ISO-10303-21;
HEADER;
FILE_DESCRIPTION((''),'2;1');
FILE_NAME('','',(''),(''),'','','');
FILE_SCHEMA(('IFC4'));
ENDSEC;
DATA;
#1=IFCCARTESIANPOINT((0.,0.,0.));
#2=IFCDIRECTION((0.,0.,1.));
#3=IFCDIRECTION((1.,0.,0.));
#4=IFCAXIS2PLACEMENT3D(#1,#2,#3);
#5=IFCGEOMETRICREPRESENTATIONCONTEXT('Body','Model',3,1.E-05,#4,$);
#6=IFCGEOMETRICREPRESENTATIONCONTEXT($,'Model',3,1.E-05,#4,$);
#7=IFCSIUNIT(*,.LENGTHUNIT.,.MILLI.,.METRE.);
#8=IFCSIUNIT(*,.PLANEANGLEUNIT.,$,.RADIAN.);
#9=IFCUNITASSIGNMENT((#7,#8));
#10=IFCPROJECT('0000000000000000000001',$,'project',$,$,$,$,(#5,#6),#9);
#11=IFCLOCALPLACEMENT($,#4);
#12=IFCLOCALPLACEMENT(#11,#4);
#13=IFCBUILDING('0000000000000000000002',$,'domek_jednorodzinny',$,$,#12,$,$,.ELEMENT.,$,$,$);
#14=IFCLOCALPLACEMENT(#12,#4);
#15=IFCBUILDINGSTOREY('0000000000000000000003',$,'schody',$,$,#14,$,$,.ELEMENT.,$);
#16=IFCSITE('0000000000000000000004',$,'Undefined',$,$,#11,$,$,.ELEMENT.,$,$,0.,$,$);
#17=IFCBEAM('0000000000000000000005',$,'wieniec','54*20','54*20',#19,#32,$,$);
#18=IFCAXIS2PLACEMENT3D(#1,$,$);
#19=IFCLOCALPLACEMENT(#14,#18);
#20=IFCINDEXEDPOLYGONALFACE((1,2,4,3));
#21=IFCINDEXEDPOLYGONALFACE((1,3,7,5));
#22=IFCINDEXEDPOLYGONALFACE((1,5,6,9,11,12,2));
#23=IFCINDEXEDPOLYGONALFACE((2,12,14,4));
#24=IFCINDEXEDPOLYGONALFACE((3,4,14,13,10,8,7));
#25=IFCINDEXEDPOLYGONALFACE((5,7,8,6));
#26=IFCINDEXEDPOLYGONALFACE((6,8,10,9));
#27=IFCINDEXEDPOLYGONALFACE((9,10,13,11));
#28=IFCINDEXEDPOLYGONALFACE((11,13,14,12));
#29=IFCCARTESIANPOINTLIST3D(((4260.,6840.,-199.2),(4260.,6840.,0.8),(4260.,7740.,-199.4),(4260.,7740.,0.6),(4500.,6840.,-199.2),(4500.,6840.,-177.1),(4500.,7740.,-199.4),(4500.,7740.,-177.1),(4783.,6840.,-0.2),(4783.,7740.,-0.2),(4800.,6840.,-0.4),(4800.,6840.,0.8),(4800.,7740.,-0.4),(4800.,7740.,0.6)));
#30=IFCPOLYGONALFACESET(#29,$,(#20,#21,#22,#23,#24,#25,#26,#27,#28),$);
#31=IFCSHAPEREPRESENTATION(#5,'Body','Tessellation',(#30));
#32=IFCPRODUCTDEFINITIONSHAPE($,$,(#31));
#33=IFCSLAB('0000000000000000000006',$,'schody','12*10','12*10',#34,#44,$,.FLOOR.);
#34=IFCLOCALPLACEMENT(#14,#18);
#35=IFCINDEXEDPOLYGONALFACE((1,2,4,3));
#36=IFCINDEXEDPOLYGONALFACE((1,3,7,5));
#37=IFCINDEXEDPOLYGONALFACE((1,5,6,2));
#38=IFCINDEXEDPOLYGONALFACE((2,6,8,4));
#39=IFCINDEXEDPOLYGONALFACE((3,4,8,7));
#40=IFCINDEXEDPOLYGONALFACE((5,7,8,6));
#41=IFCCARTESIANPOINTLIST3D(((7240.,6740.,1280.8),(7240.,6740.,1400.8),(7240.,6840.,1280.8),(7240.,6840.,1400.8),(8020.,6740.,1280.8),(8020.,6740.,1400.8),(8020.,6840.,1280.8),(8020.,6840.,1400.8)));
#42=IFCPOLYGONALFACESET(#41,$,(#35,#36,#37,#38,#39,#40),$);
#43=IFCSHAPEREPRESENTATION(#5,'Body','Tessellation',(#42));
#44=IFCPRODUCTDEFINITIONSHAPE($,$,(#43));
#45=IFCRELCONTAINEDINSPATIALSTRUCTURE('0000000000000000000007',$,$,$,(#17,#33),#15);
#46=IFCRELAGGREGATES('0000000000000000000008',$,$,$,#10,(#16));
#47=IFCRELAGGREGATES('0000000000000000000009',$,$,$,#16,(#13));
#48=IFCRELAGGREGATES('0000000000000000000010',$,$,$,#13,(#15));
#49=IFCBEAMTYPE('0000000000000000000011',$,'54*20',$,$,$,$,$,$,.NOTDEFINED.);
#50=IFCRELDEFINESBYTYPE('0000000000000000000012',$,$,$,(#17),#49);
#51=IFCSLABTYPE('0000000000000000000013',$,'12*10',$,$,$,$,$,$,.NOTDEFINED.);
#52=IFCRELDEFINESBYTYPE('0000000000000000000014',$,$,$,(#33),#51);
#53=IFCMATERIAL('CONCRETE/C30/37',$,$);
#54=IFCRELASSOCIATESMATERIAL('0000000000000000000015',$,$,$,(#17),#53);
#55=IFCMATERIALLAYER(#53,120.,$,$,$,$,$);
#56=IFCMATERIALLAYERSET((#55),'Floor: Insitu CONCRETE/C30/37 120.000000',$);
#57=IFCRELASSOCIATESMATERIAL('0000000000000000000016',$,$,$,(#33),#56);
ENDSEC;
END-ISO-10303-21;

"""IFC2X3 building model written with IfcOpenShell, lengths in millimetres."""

from ifc_helpers import new_model, si_unit, frame, origin_with_axes, origin_2d_with_axis, place, context, project, spatial, polyline, rectangle, outline, extrude, material, layer, layer_set, layer_usage, type_object, element, save


model = new_model("IFC2X3")

# Units and contexts
model_context_1 = context("Model", 3, precision=1e-05, world=origin_with_axes(), identifier="Body")
model_context_2 = context("Model", 3, precision=1e-05, world=origin_with_axes())
ifc_project = project(units=[si_unit("LENGTHUNIT", "METRE", prefix="MILLI"), si_unit("PLANEANGLEUNIT", "RADIAN")], contexts=[model_context_1, model_context_2])

# Site, building, storey
site_placement = place(None, origin_with_axes())
site = spatial("IfcSite", under=ifc_project, at=site_placement, Name="Undefined", CompositionType="ELEMENT", RefElevation=0.0)
building_placement = place(site_placement, origin_with_axes())
building = spatial("IfcBuilding", under=site, at=building_placement, Name="domek_jednorodzinny", CompositionType="ELEMENT")
storey_placement = place(building_placement, origin_with_axes())
storey = spatial("IfcBuildingStorey", under=building, at=storey_placement, Name="schody", CompositionType="ELEMENT")

# Beam, opening
ifc_material = material(Name="CONCRETE/C30/37")
beam_type = type_object("IfcBeamType", Name="54*20", PredefinedType="NOTDEFINED")
beam_placement = place(storey_placement, frame((4530.0, 7740.0, -99.4), z_axis=(0.0, 0.000179, 1.0), x_axis=(0.0, -1.0, 0.000179)))
beam = element("IfcBeam", 1, at=beam_placement, inside=storey, type_object=beam_type, material=ifc_material, Name="wieniec", Description="54*20", ObjectType="54*20", context=model_context_1, shape_type="SweptSolid", body=[
    extrude(rectangle(XDim=540.0, YDim=200.0, at=origin_2d_with_axis()), frame((900.0, 0.0, 0.0), z_axis=(-1.0, 0.0, 0.0), x_axis=(0.0, -1.0, 0.0)), (0.0, 0.0, 1.0), 900.0),
])
opening_1_placement = place(storey_placement, frame((4530.0, 7740.0, -99.4), z_axis=(0.0, 0.000179, 1.0), x_axis=(0.0, -1.0, 0.000179)))
element("IfcOpeningElement", 2, at=opening_1_placement, cuts=beam, ObjectType="Recess", context=model_context_1, shape_type="SweptSolid", body=[
    extrude(outline(polyline([(0.0, 0.0), (333.7, 0.0), (346.0, 19.6), (91.7, 178.7), (-14.3, 9.1), (0.0, 0.0)])), frame((-3.0, 253.0, 99.2), z_axis=(1.0, 0.0, -0.000179), x_axis=(-0.000095, -0.847998, -0.529999)), (0.0, 0.0, 1.0), 906.0),
])

# Slab
ifc_layer_1 = layer(ifc_material, 120.0)
ifc_layer_set_1 = layer_set([ifc_layer_1], Name="Floor: Insitu CONCRETE/C30/37 120.000000")
ifc_layer_usage_1 = layer_usage(ifc_layer_set_1, "AXIS3", "POSITIVE", -60.0)
slab_type_1 = type_object("IfcSlabType", Name="12*10", PredefinedType="NOTDEFINED")
slab_1_placement = place(storey_placement, frame((7240.0, 6840.0, 1340.8), z_axis=(0.000001, 0.000001, -1.0), x_axis=(1.0, 0.0, 0.0)))
element("IfcSlab", 3, at=slab_1_placement, inside=storey, type_object=slab_type_1, material=ifc_layer_usage_1, Name="schody", Description="12*10", ObjectType="12*10", PredefinedType="FLOOR", context=model_context_1, shape_type="SweptSolid", body=[
    extrude(outline(polyline([(0.0, 0.0), (780.0, 0.0), (780.0, 100.0), (0.0, 100.0), (0.0, 0.0)])), frame((0.0, 0.0, -60.0), z_axis=(0.0, 0.0, 1.0), x_axis=(1.0, 0.0, 0.0)), (0.0, 0.0, 1.0), 120.0),
])

save(model, "model.ifc")
